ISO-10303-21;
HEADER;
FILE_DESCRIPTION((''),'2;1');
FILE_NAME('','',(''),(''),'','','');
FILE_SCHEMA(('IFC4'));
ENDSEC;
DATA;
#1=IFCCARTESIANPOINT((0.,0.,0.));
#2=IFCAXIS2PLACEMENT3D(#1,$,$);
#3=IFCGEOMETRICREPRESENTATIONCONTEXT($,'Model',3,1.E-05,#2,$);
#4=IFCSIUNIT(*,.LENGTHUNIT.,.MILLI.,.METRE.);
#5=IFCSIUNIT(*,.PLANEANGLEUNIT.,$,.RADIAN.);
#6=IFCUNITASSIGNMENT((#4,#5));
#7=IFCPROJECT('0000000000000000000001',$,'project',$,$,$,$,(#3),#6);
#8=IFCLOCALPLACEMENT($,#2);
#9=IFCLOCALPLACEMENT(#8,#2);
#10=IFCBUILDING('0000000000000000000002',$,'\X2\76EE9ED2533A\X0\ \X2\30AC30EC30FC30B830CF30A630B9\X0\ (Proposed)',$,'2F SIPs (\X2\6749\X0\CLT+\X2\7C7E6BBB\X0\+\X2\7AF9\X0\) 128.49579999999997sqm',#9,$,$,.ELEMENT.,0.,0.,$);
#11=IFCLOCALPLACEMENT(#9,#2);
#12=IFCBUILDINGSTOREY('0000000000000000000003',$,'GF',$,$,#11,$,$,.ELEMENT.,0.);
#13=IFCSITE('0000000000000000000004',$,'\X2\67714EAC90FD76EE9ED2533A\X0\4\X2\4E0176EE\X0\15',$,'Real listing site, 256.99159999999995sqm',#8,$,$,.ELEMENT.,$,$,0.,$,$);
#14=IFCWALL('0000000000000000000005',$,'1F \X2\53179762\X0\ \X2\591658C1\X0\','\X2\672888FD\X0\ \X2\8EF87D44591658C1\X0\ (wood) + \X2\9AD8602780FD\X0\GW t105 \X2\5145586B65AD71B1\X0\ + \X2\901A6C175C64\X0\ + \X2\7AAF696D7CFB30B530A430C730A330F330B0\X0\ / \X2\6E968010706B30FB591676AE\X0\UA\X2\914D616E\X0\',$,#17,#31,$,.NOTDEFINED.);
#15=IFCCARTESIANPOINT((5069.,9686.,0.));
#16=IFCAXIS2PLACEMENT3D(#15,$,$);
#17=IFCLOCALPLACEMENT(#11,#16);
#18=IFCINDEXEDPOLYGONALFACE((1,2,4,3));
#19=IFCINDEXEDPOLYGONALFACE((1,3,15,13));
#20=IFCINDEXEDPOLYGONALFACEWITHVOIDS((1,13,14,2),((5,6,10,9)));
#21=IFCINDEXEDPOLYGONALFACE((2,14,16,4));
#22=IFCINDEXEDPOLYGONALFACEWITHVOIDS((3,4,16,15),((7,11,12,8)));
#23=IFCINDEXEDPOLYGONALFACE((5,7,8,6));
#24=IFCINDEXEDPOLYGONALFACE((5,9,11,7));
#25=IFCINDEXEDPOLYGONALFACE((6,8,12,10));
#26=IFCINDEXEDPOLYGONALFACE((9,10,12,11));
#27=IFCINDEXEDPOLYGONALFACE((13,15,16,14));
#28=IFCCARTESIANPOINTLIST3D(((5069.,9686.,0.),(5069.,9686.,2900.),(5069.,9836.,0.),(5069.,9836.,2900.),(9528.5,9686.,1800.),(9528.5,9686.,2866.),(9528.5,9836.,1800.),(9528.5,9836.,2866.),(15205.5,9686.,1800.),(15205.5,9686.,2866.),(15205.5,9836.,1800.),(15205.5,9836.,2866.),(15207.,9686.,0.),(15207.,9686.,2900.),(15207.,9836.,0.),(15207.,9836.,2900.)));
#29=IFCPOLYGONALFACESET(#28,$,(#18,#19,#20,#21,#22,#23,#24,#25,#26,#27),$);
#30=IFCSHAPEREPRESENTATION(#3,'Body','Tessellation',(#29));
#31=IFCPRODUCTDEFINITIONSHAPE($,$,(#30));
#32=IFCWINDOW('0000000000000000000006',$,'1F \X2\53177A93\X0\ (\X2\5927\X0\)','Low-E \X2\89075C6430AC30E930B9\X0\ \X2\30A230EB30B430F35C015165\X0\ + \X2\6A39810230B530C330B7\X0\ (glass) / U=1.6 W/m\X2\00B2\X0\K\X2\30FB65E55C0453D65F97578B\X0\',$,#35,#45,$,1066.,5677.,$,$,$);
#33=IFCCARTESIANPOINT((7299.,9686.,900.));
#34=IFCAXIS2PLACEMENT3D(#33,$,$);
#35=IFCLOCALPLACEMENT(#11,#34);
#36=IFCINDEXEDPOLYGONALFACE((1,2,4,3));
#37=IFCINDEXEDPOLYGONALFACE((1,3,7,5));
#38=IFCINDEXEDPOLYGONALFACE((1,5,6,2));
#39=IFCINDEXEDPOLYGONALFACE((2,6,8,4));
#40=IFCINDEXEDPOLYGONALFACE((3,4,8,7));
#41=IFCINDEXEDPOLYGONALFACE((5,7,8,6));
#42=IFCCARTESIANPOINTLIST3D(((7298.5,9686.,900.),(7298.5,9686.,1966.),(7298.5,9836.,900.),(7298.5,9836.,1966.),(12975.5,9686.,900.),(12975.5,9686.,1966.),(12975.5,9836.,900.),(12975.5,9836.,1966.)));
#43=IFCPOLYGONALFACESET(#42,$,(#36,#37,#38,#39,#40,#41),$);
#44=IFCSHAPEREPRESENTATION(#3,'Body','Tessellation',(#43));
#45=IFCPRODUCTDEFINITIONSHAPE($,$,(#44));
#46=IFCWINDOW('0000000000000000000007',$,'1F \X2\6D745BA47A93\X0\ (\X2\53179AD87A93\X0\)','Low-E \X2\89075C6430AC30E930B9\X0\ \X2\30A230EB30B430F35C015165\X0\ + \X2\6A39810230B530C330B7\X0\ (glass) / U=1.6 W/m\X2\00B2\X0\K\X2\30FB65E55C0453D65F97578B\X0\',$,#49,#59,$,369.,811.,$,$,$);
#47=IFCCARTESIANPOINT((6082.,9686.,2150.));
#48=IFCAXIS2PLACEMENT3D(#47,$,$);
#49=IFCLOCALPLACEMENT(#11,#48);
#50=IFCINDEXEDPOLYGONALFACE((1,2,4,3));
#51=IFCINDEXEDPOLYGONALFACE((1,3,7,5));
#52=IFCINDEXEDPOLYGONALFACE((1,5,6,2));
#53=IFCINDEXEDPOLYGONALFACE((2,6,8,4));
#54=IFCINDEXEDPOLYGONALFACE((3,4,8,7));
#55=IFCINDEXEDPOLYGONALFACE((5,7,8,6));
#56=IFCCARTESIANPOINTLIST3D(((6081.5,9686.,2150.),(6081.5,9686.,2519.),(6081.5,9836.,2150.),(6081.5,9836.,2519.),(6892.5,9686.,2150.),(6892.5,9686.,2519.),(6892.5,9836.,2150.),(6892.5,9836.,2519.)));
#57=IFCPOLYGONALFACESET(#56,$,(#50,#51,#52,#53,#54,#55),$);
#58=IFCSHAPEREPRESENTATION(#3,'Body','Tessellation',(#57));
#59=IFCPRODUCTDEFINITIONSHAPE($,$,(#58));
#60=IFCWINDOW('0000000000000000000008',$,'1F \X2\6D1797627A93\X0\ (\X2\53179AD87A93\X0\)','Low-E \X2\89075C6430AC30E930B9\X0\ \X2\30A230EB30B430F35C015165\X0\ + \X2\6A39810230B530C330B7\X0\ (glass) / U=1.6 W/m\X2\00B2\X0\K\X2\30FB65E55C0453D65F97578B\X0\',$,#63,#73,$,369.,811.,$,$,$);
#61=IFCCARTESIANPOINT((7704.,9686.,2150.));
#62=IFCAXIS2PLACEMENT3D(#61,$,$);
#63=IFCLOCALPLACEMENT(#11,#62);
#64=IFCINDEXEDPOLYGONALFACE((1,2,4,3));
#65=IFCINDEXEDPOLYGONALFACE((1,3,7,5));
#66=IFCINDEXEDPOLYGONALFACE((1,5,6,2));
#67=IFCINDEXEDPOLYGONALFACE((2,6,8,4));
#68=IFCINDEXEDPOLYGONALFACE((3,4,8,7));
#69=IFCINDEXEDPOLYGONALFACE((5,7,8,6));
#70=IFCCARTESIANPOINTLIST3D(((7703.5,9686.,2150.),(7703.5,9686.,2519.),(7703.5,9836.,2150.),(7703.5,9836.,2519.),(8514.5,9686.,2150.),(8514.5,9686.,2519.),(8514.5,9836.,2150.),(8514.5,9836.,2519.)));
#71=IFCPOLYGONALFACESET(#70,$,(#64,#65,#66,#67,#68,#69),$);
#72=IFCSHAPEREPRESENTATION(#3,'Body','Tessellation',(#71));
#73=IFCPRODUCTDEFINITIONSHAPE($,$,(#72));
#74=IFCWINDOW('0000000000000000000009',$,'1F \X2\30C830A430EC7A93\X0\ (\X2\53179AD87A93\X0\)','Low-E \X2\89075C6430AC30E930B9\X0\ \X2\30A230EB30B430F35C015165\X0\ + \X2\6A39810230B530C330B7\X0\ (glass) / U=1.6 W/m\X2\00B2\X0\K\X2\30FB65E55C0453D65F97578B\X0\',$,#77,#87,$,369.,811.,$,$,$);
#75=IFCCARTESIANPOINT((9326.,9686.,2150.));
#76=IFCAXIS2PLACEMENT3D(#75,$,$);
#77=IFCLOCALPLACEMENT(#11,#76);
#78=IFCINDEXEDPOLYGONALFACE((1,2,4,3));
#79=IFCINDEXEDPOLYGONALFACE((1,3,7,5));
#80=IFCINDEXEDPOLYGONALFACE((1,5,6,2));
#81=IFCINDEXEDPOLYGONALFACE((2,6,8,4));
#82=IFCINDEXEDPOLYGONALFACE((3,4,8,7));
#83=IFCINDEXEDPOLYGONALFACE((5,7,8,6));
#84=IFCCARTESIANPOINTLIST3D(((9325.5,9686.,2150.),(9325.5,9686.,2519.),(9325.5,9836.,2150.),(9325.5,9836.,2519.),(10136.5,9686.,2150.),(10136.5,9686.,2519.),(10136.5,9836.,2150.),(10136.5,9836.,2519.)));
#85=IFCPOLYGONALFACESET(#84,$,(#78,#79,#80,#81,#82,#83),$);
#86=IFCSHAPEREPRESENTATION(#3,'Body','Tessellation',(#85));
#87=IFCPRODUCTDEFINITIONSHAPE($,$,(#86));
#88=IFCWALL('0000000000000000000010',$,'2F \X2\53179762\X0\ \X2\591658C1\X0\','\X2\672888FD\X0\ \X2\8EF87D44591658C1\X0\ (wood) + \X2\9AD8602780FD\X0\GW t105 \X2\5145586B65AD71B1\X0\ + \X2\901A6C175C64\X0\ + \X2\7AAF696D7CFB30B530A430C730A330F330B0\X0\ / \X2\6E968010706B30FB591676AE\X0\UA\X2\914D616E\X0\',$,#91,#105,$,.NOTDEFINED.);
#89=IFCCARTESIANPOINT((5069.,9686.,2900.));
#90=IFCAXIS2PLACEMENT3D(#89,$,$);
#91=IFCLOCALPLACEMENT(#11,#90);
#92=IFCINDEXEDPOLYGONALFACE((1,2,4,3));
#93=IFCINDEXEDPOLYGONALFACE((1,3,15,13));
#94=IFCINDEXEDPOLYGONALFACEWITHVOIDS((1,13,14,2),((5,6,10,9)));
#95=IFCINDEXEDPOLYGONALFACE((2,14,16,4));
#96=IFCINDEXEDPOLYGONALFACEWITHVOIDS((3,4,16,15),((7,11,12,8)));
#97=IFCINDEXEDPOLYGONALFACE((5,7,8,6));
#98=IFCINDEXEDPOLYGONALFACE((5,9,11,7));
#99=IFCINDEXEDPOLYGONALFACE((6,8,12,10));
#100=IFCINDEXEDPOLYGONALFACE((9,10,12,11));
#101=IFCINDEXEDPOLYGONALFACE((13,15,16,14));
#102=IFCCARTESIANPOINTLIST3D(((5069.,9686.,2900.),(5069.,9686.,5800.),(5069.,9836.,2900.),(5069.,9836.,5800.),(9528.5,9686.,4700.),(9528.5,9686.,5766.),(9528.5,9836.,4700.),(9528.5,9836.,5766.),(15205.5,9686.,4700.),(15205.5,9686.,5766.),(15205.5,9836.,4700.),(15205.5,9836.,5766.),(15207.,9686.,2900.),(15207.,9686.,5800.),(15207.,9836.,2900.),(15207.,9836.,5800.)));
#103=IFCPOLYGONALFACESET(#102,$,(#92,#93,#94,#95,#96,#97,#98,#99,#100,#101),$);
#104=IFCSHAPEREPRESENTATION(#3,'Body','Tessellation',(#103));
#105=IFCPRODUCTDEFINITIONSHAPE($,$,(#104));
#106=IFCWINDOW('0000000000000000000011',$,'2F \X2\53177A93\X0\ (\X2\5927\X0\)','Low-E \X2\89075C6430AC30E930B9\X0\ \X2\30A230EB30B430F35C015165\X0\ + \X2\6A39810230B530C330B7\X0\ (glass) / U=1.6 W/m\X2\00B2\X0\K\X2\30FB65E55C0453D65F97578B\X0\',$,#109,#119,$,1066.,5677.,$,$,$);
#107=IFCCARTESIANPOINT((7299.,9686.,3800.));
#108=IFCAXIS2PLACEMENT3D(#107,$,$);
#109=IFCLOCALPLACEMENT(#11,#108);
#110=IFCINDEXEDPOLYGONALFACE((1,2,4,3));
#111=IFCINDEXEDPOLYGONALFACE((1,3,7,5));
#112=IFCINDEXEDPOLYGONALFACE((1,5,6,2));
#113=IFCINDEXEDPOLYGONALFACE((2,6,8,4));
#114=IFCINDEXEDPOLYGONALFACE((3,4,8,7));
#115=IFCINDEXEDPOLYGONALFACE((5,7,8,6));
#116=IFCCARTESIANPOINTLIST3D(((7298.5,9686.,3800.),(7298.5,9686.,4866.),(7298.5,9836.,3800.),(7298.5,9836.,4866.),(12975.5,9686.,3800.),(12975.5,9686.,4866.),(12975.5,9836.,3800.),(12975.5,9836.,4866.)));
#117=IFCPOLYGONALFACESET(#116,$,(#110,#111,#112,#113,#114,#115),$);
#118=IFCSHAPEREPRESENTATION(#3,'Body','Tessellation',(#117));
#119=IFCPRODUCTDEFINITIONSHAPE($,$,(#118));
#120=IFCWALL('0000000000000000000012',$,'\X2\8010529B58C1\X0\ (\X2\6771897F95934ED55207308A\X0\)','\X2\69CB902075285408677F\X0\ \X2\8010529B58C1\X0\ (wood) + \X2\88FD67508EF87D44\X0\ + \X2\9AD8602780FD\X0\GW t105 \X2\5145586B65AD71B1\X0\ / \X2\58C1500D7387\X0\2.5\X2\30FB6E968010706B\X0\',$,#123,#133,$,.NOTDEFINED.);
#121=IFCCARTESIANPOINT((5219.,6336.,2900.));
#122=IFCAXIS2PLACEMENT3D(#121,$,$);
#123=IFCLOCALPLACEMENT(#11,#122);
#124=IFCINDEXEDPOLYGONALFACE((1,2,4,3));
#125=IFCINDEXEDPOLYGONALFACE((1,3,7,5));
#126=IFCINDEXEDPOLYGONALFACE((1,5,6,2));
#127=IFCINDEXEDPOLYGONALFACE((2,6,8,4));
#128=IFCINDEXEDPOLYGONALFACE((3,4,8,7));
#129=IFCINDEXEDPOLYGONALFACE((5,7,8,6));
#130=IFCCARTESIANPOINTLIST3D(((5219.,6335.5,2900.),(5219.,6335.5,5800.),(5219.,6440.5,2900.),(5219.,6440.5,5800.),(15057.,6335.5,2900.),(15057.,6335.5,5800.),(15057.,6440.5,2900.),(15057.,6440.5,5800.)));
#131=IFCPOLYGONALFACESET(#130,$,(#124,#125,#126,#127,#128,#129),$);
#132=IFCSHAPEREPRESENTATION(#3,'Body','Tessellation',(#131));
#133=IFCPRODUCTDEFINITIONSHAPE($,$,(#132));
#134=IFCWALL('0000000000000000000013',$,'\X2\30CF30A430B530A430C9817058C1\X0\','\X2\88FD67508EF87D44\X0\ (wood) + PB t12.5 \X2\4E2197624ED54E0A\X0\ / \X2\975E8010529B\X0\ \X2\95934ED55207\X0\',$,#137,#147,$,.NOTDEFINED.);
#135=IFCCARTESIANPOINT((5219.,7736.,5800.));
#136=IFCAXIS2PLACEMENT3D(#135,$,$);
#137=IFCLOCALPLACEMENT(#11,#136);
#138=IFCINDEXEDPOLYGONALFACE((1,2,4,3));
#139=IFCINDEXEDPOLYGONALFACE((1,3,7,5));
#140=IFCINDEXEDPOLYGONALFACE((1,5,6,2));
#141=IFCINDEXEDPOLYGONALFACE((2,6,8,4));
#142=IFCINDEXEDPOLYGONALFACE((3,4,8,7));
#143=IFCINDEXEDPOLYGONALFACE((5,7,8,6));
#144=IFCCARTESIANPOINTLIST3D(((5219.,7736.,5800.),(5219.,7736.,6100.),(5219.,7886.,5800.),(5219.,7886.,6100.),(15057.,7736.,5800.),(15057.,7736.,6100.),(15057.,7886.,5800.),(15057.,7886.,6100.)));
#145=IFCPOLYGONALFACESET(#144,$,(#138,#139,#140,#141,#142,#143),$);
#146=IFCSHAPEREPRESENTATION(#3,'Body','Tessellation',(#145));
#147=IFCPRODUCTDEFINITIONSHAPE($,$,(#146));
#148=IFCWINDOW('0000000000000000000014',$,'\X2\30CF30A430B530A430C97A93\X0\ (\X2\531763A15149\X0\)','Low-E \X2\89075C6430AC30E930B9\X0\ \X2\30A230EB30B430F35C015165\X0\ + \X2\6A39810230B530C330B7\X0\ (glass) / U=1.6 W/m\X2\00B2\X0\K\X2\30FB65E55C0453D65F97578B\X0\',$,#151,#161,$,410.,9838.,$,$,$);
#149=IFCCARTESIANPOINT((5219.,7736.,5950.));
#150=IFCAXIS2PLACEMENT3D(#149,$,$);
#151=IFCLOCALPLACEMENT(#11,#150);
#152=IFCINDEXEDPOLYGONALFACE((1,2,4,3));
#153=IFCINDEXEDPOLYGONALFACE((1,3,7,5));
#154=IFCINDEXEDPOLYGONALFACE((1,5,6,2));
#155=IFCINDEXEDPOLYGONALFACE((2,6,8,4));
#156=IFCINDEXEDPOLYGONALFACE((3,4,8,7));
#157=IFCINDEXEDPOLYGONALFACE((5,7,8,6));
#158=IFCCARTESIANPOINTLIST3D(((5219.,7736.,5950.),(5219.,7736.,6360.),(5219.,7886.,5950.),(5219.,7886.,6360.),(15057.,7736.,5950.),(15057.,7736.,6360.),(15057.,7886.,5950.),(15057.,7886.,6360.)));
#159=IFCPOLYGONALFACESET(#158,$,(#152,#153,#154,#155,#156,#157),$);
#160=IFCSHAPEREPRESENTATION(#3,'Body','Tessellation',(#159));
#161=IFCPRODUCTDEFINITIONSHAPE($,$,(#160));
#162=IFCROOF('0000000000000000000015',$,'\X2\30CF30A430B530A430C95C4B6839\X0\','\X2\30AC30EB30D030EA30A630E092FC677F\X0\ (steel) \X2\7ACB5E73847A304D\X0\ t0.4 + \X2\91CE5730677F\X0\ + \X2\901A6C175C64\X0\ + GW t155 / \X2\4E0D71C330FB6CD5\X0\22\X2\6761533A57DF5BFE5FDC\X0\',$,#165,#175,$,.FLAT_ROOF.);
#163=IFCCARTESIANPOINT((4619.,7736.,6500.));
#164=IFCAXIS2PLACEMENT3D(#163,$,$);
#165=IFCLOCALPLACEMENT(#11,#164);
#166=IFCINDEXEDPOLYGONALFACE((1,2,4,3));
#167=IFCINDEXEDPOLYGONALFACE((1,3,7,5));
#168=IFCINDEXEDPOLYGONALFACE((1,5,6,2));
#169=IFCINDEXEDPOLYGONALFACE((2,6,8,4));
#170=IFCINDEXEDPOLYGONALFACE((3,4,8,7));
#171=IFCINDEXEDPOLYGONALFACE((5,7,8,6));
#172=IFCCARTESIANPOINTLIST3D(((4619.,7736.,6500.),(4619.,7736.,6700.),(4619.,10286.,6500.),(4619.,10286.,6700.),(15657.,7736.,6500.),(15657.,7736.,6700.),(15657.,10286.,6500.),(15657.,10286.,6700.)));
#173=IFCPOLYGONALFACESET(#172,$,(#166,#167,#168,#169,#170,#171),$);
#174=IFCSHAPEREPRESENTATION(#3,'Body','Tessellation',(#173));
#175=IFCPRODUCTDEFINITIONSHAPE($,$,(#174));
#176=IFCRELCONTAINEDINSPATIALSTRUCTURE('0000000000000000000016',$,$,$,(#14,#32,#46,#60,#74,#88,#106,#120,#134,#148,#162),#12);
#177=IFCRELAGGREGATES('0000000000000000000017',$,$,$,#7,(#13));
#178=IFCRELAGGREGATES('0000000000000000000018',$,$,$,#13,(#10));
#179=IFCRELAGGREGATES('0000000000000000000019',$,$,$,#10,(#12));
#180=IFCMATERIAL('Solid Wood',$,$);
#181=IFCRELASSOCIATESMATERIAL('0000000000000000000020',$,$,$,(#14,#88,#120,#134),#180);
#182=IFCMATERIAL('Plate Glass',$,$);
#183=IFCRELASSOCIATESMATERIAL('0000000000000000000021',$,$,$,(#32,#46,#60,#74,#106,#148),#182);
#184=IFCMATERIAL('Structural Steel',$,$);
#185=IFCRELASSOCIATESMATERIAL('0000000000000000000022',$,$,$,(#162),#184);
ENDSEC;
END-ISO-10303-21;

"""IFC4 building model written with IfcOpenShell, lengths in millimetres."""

from ifc_helpers import new_model, si_unit, frame, frame_2d, origin, place, context, project, spatial, rectangle, extrude, material, element, fill, save


model = new_model("IFC4")

# Units and contexts
model_context = context("Model", 3, precision=1e-05, world=origin())
ifc_project = project(units=[si_unit("LENGTHUNIT", "METRE", prefix="MILLI"), si_unit("PLANEANGLEUNIT", "RADIAN")], contexts=[model_context])

# Site, building, storey
site_placement = place(None, origin())
site = spatial("IfcSite", under=ifc_project, at=site_placement, Name="東京都目黒区4丁目15", ObjectType="Real listing site, 256.99159999999995sqm", CompositionType="ELEMENT", RefElevation=0.0)
building_placement = place(site_placement, origin())
building = spatial("IfcBuilding", under=site, at=building_placement, Name="目黒区 ガレージハウス (Proposed)", ObjectType="2F SIPs (杉CLT+籾殻+竹) 128.49579999999997sqm", CompositionType="ELEMENT", ElevationOfRefHeight=0.0, ElevationOfTerrain=0.0)
storey_placement = place(building_placement, origin())
storey = spatial("IfcBuildingStorey", under=building, at=storey_placement, Name="GF", CompositionType="ELEMENT", Elevation=0.0)

# Wall, openings, windows
ifc_material_1 = material(Name="Solid Wood")
wall_1_placement = place(storey_placement, frame((5069.0, 9686.0, 0.0)))
wall_1 = element("IfcWall", 1, at=wall_1_placement, inside=storey, material=ifc_material_1, Name="1F 北面 外壁", Description="木製 軸組外壁 (wood) + 高性能GW t105 充填断熱 + 通気層 + 窯業系サイディング / 準耐火・外皮UA配慮", PredefinedType="NOTDEFINED", context=model_context, shape_type="SweptSolid", body=[
    extrude(rectangle(XDim=10138.0, YDim=150.0, at=frame_2d((5069.0, 75.0))), frame((5069.0, 9686.0, 0.0)), (0.0, 0.0, 1.0), 2900.0),
])
opening_1_placement = place(storey_placement, frame((7299.0, 9686.0, 900.0)))
opening_1 = element("IfcOpeningElement", 2, at=opening_1_placement, cuts=wall_1, PredefinedType="NOTDEFINED", context=model_context, shape_type="SweptSolid", body=[
    extrude(rectangle(XDim=5677.0, YDim=150.0, at=frame_2d((2838.0, 75.0))), frame((7299.0, 9686.0, 900.0)), (0.0, 0.0, 1.0), 1066.0),
])
opening_2_placement = place(storey_placement, frame((6082.0, 9686.0, 2150.0)))
opening_2 = element("IfcOpeningElement", 3, at=opening_2_placement, cuts=wall_1, PredefinedType="NOTDEFINED", context=model_context, shape_type="SweptSolid", body=[
    extrude(rectangle(XDim=811.0, YDim=150.0, at=frame_2d((405.0, 75.0))), frame((6082.0, 9686.0, 2150.0)), (0.0, 0.0, 1.0), 369.0),
])
opening_3_placement = place(storey_placement, frame((7704.0, 9686.0, 2150.0)))
opening_3 = element("IfcOpeningElement", 4, at=opening_3_placement, cuts=wall_1, PredefinedType="NOTDEFINED", context=model_context, shape_type="SweptSolid", body=[
    extrude(rectangle(XDim=811.0, YDim=150.0, at=frame_2d((405.0, 75.0))), frame((7704.0, 9686.0, 2150.0)), (0.0, 0.0, 1.0), 369.0),
])
opening_4_placement = place(storey_placement, frame((9326.0, 9686.0, 2150.0)))
opening_4 = element("IfcOpeningElement", 5, at=opening_4_placement, cuts=wall_1, PredefinedType="NOTDEFINED", context=model_context, shape_type="SweptSolid", body=[
    extrude(rectangle(XDim=811.0, YDim=150.0, at=frame_2d((405.0, 75.0))), frame((9326.0, 9686.0, 2150.0)), (0.0, 0.0, 1.0), 369.0),
])
ifc_material_2 = material(Name="Plate Glass")
window_1_placement = place(storey_placement, frame((7299.0, 9686.0, 900.0)))
window_1 = element("IfcWindow", 6, at=window_1_placement, inside=storey, material=ifc_material_2, Name="1F 北窓 (大)", Description="Low-E 複層ガラス アルゴン封入 + 樹脂サッシ (glass) / U=1.6 W/m²K・日射取得型", OverallHeight=1066.0, OverallWidth=5677.0, context=model_context, shape_type="SweptSolid", body=[
    extrude(rectangle(XDim=5677.0, YDim=150.0, at=frame_2d((2838.0, 75.0))), frame((7299.0, 9686.0, 900.0)), (0.0, 0.0, 1.0), 1066.0),
])
fill(opening_1, window_1)
window_2_placement = place(storey_placement, frame((6082.0, 9686.0, 2150.0)))
window_2 = element("IfcWindow", 7, at=window_2_placement, inside=storey, material=ifc_material_2, Name="1F 浴室窓 (北高窓)", Description="Low-E 複層ガラス アルゴン封入 + 樹脂サッシ (glass) / U=1.6 W/m²K・日射取得型", OverallHeight=369.0, OverallWidth=811.0, context=model_context, shape_type="SweptSolid", body=[
    extrude(rectangle(XDim=811.0, YDim=150.0, at=frame_2d((405.0, 75.0))), frame((6082.0, 9686.0, 2150.0)), (0.0, 0.0, 1.0), 369.0),
])
fill(opening_2, window_2)
window_3_placement = place(storey_placement, frame((7704.0, 9686.0, 2150.0)))
window_3 = element("IfcWindow", 8, at=window_3_placement, inside=storey, material=ifc_material_2, Name="1F 洗面窓 (北高窓)", Description="Low-E 複層ガラス アルゴン封入 + 樹脂サッシ (glass) / U=1.6 W/m²K・日射取得型", OverallHeight=369.0, OverallWidth=811.0, context=model_context, shape_type="SweptSolid", body=[
    extrude(rectangle(XDim=811.0, YDim=150.0, at=frame_2d((405.0, 75.0))), frame((7704.0, 9686.0, 2150.0)), (0.0, 0.0, 1.0), 369.0),
])
fill(opening_3, window_3)
window_4_placement = place(storey_placement, frame((9326.0, 9686.0, 2150.0)))
window_4 = element("IfcWindow", 9, at=window_4_placement, inside=storey, material=ifc_material_2, Name="1F トイレ窓 (北高窓)", Description="Low-E 複層ガラス アルゴン封入 + 樹脂サッシ (glass) / U=1.6 W/m²K・日射取得型", OverallHeight=369.0, OverallWidth=811.0, context=model_context, shape_type="SweptSolid", body=[
    extrude(rectangle(XDim=811.0, YDim=150.0, at=frame_2d((405.0, 75.0))), frame((9326.0, 9686.0, 2150.0)), (0.0, 0.0, 1.0), 369.0),
])
fill(opening_4, window_4)

# Wall, opening, window
wall_2_placement = place(storey_placement, frame((5069.0, 9686.0, 2900.0)))
wall_2 = element("IfcWall", 10, at=wall_2_placement, inside=storey, material=ifc_material_1, Name="2F 北面 外壁", Description="木製 軸組外壁 (wood) + 高性能GW t105 充填断熱 + 通気層 + 窯業系サイディング / 準耐火・外皮UA配慮", PredefinedType="NOTDEFINED", context=model_context, shape_type="SweptSolid", body=[
    extrude(rectangle(XDim=10138.0, YDim=150.0, at=frame_2d((5069.0, 75.0))), frame((5069.0, 9686.0, 2900.0)), (0.0, 0.0, 1.0), 2900.0),
])
opening_5_placement = place(storey_placement, frame((7299.0, 9686.0, 3800.0)))
opening_5 = element("IfcOpeningElement", 11, at=opening_5_placement, cuts=wall_2, PredefinedType="NOTDEFINED", context=model_context, shape_type="SweptSolid", body=[
    extrude(rectangle(XDim=5677.0, YDim=150.0, at=frame_2d((2838.0, 75.0))), frame((7299.0, 9686.0, 3800.0)), (0.0, 0.0, 1.0), 1066.0),
])
window_5_placement = place(storey_placement, frame((7299.0, 9686.0, 3800.0)))
window_5 = element("IfcWindow", 12, at=window_5_placement, inside=storey, material=ifc_material_2, Name="2F 北窓 (大)", Description="Low-E 複層ガラス アルゴン封入 + 樹脂サッシ (glass) / U=1.6 W/m²K・日射取得型", OverallHeight=1066.0, OverallWidth=5677.0, context=model_context, shape_type="SweptSolid", body=[
    extrude(rectangle(XDim=5677.0, YDim=150.0, at=frame_2d((2838.0, 75.0))), frame((7299.0, 9686.0, 3800.0)), (0.0, 0.0, 1.0), 1066.0),
])
fill(opening_5, window_5)

# Wall
wall_3_placement = place(storey_placement, frame((5219.0, 6336.0, 2900.0)))
element("IfcWall", 13, at=wall_3_placement, inside=storey, material=ifc_material_1, Name="耐力壁 (東西間仕切り)", Description="構造用合板 耐力壁 (wood) + 製材軸組 + 高性能GW t105 充填断熱 / 壁倍率2.5・準耐火", PredefinedType="NOTDEFINED", context=model_context, shape_type="SweptSolid", body=[
    extrude(rectangle(XDim=9838.0, YDim=105.0, at=frame_2d((4919.0, 52.0))), frame((5219.0, 6336.0, 2900.0)), (0.0, 0.0, 1.0), 2900.0),
])

# Wall, opening, window
wall_4_placement = place(storey_placement, frame((5219.0, 7736.0, 5800.0)))
wall_4 = element("IfcWall", 14, at=wall_4_placement, inside=storey, material=ifc_material_1, Name="ハイサイド腰壁", Description="製材軸組 (wood) + PB t12.5 両面仕上 / 非耐力 間仕切", PredefinedType="NOTDEFINED", context=model_context, shape_type="SweptSolid", body=[
    extrude(rectangle(XDim=9838.0, YDim=150.0, at=frame_2d((4919.0, 75.0))), frame((5219.0, 7736.0, 5800.0)), (0.0, 0.0, 1.0), 700.0),
])
opening_6_placement = place(storey_placement, frame((5219.0, 7736.0, 5950.0)))
opening_6 = element("IfcOpeningElement", 15, at=opening_6_placement, cuts=wall_4, PredefinedType="NOTDEFINED", context=model_context, shape_type="SweptSolid", body=[
    extrude(rectangle(XDim=9838.0, YDim=150.0, at=frame_2d((4919.0, 75.0))), frame((5219.0, 7736.0, 5950.0)), (0.0, 0.0, 1.0), 410.0),
])
window_6_placement = place(storey_placement, frame((5219.0, 7736.0, 5950.0)))
window_6 = element("IfcWindow", 16, at=window_6_placement, inside=storey, material=ifc_material_2, Name="ハイサイド窓 (北採光)", Description="Low-E 複層ガラス アルゴン封入 + 樹脂サッシ (glass) / U=1.6 W/m²K・日射取得型", OverallHeight=410.0, OverallWidth=9838.0, context=model_context, shape_type="SweptSolid", body=[
    extrude(rectangle(XDim=9838.0, YDim=150.0, at=frame_2d((4919.0, 75.0))), frame((5219.0, 7736.0, 5950.0)), (0.0, 0.0, 1.0), 410.0),
])
fill(opening_6, window_6)

# Roof
ifc_material_3 = material(Name="Structural Steel")
roof_placement = place(storey_placement, frame((4619.0, 7736.0, 6500.0)))
element("IfcRoof", 17, at=roof_placement, inside=storey, material=ifc_material_3, Name="ハイサイド屋根", Description="ガルバリウム鋼板 (steel) 立平葺き t0.4 + 野地板 + 通気層 + GW t155 / 不燃・法22条区域対応", PredefinedType="FLAT_ROOF", context=model_context, shape_type="SweptSolid", body=[
    extrude(rectangle(XDim=11038.0, YDim=2550.0, at=frame_2d((5519.0, 1275.0))), frame((4619.0, 7736.0, 6500.0)), (0.0, 0.0, 1.0), 200.0),
])

save(model, "model.ifc")
